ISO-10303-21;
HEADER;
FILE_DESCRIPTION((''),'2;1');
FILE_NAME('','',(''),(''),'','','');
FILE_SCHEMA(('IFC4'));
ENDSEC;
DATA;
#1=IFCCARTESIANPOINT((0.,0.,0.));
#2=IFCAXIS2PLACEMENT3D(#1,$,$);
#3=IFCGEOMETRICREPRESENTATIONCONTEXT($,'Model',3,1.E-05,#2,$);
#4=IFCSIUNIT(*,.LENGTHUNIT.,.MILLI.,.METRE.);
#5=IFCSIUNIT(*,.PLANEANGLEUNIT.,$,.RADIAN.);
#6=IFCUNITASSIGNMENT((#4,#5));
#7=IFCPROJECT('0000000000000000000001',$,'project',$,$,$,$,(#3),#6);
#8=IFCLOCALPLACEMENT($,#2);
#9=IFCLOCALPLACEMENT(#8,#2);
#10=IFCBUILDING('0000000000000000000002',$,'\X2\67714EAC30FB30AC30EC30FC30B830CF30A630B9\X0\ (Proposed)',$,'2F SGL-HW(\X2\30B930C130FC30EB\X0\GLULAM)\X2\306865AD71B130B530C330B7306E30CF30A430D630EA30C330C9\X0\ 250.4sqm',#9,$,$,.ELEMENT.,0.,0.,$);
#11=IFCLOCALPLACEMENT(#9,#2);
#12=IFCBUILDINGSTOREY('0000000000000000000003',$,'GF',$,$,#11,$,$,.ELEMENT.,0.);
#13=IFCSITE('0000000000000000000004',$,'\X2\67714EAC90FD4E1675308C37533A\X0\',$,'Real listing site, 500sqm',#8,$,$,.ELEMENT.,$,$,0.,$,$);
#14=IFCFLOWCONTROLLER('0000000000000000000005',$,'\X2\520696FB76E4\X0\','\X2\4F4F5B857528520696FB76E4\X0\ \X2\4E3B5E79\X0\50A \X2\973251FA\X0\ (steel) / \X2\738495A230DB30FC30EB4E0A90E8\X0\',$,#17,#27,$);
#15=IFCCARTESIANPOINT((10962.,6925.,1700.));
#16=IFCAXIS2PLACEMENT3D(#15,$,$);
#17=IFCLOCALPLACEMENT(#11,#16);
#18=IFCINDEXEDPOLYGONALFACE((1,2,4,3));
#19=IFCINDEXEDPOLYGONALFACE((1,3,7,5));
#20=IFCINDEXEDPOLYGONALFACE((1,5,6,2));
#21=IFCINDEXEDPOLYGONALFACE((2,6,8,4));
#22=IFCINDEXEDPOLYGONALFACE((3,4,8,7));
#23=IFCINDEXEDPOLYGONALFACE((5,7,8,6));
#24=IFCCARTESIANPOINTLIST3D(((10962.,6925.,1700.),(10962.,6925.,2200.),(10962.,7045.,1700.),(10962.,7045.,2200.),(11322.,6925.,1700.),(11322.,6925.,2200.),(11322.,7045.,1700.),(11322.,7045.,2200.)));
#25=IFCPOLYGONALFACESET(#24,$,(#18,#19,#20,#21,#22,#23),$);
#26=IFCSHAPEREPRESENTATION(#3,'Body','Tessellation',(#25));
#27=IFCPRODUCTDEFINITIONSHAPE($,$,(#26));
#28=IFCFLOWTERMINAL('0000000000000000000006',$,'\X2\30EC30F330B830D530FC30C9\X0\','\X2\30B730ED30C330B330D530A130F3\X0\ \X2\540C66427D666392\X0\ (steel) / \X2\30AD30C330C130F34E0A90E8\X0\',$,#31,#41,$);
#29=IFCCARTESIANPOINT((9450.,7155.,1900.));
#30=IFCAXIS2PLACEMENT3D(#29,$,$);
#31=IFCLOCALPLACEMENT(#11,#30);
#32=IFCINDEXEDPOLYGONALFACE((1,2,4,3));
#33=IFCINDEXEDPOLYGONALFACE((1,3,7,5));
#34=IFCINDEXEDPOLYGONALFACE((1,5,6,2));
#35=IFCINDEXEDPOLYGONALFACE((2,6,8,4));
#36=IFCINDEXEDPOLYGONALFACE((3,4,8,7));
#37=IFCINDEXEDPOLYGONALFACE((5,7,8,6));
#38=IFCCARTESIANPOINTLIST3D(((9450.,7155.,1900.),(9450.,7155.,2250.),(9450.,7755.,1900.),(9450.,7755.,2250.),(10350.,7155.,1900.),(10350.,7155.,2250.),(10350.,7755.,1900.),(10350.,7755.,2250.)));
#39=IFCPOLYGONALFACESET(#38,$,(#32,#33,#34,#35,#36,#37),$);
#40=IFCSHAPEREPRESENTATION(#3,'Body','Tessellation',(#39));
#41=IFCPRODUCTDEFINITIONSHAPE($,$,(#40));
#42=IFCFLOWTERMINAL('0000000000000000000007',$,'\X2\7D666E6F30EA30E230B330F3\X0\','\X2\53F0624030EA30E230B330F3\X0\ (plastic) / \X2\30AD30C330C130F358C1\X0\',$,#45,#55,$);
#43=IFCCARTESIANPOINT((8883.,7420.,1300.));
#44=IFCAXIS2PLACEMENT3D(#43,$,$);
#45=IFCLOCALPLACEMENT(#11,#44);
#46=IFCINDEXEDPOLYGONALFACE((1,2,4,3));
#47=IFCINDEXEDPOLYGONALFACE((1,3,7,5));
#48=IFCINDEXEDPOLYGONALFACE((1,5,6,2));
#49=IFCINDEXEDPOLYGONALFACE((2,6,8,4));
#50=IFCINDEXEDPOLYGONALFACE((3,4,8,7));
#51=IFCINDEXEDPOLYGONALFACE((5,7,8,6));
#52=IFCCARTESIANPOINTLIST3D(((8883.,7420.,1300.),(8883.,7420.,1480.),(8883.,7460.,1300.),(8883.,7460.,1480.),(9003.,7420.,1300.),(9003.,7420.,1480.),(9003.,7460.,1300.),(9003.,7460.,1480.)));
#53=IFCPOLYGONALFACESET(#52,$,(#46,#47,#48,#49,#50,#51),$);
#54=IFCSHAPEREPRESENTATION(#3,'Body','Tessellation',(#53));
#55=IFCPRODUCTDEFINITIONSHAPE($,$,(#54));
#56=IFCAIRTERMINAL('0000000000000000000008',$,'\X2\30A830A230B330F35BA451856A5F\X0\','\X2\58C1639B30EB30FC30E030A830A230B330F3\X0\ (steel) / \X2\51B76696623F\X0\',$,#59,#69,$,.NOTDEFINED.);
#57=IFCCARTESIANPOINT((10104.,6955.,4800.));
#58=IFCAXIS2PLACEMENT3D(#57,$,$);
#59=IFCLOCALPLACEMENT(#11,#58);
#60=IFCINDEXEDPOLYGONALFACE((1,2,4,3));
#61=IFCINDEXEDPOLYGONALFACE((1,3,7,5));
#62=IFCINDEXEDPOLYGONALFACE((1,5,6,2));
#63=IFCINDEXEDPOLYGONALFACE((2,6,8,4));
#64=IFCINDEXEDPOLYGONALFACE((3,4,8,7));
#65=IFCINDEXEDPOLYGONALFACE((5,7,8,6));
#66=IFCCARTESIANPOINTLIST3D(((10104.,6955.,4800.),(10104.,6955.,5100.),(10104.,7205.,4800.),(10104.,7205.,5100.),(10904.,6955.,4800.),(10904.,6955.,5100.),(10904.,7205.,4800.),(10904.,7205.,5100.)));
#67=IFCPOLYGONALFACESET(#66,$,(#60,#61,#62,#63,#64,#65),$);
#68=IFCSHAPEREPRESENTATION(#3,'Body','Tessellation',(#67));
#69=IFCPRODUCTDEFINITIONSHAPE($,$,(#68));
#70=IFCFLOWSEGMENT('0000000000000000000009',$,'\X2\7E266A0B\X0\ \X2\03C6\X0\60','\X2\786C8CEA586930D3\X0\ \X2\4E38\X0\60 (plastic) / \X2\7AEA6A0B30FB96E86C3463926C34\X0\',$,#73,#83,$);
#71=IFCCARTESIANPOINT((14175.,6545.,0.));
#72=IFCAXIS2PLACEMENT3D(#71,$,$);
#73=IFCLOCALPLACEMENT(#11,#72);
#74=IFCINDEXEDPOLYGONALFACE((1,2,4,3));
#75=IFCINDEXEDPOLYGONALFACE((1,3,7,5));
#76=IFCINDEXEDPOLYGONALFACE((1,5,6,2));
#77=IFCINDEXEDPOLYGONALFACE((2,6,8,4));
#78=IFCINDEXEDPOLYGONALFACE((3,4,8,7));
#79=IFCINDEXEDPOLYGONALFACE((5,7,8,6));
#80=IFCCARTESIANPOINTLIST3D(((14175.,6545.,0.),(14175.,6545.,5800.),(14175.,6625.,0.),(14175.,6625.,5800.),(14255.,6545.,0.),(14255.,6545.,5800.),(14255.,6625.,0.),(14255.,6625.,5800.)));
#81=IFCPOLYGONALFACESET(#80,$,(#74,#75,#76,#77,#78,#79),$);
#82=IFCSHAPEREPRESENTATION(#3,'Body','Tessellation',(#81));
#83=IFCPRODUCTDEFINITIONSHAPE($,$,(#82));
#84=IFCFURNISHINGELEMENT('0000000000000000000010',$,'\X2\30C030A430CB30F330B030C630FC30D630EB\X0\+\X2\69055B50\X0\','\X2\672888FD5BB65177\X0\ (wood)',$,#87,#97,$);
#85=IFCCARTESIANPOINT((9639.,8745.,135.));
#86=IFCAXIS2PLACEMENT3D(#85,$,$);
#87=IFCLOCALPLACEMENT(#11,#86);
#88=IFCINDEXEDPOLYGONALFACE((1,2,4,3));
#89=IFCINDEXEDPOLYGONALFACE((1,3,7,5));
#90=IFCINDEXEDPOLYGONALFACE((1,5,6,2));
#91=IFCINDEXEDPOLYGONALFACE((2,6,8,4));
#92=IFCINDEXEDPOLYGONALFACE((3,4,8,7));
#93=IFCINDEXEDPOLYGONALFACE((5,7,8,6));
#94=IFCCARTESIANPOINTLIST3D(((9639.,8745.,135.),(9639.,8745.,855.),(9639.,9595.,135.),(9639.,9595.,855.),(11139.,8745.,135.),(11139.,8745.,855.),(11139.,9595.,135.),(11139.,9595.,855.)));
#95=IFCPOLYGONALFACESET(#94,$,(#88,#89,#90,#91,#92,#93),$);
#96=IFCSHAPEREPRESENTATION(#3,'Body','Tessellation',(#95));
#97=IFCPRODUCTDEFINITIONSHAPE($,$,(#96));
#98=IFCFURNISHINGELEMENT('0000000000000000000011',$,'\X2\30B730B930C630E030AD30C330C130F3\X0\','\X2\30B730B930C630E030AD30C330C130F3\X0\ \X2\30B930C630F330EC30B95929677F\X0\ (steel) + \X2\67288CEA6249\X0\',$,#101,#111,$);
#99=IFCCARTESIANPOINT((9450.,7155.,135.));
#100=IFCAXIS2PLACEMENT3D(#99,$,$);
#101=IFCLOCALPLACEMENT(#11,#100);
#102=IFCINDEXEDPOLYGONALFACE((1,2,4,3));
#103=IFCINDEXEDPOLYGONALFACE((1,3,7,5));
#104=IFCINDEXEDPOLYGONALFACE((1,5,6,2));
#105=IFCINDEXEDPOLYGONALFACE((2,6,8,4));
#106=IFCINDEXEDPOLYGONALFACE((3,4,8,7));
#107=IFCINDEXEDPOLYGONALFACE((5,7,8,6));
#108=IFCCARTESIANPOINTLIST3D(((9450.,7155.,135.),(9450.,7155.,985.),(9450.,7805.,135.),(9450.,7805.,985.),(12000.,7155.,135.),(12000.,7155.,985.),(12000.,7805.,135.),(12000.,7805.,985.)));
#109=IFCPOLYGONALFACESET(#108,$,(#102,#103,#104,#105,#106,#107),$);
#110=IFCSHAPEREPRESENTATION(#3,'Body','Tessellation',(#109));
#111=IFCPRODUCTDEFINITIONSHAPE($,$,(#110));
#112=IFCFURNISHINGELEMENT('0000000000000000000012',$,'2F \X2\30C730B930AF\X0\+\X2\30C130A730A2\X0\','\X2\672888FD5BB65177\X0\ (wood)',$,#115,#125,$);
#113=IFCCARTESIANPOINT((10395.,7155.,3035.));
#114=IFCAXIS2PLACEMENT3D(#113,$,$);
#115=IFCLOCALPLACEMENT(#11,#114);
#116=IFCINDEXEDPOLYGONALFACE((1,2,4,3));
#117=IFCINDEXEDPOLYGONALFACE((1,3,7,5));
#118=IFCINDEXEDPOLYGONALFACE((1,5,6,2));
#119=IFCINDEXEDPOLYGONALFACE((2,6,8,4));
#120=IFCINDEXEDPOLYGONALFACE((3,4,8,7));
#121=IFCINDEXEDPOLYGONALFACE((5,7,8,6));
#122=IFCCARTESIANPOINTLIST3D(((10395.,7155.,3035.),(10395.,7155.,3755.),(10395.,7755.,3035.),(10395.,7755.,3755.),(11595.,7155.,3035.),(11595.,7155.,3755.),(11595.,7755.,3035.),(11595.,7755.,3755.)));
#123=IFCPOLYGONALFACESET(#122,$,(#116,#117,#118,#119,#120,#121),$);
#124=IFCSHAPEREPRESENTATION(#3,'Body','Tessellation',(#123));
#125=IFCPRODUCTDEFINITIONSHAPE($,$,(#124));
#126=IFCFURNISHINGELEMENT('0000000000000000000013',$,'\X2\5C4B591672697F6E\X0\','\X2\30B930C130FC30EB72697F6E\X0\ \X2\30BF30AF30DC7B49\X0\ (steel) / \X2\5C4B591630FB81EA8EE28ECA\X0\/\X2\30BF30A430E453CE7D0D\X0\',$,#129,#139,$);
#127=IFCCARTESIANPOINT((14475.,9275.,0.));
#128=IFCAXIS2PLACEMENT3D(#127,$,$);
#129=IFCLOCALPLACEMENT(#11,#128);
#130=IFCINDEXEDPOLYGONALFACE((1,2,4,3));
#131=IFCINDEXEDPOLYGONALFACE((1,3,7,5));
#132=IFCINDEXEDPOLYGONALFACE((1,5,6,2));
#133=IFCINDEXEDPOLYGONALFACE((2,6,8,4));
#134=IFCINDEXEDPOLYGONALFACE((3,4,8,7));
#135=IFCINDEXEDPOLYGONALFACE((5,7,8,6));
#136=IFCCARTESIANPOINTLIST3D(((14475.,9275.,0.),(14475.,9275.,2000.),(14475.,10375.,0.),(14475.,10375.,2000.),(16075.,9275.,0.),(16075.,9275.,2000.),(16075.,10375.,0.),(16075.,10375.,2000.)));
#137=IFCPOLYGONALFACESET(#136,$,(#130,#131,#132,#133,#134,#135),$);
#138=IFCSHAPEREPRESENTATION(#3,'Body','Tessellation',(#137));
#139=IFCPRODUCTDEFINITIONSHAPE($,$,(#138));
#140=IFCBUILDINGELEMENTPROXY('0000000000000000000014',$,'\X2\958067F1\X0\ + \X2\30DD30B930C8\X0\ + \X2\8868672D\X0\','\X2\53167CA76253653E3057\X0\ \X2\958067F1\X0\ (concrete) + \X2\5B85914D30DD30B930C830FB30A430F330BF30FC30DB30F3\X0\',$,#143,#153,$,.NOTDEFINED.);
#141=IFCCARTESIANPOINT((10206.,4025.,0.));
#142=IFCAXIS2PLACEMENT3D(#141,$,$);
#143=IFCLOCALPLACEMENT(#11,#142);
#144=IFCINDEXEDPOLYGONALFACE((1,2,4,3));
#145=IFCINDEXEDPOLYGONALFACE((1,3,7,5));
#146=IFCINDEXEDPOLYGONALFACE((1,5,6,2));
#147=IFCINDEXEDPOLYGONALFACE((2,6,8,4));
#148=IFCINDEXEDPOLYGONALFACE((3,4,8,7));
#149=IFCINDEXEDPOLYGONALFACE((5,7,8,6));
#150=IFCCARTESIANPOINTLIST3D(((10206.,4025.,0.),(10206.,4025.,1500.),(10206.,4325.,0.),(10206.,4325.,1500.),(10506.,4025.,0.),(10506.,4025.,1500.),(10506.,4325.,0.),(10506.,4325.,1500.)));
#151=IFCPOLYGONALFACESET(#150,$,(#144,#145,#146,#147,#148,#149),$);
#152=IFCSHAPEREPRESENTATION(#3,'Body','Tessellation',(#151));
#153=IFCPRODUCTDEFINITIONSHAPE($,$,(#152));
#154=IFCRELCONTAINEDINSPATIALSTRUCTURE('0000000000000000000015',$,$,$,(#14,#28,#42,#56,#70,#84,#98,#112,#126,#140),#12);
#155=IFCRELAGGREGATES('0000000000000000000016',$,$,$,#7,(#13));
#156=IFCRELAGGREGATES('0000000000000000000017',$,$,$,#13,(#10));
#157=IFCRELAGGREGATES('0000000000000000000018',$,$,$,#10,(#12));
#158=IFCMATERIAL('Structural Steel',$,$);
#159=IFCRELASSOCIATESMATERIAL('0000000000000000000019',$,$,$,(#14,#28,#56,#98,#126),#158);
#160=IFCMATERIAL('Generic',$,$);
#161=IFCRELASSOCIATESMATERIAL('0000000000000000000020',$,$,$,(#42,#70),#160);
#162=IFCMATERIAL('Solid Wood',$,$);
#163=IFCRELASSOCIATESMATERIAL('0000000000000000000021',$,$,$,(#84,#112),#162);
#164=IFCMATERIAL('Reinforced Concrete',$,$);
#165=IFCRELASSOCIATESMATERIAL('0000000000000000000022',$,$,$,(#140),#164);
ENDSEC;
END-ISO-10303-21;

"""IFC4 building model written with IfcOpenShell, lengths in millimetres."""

from ifc_helpers import new_model, si_unit, frame, frame_2d, origin, place, context, project, spatial, rectangle, extrude, material, element, save


model = new_model("IFC4")

# Units and contexts
model_context = context("Model", 3, precision=1e-05, world=origin())
ifc_project = project(units=[si_unit("LENGTHUNIT", "METRE", prefix="MILLI"), si_unit("PLANEANGLEUNIT", "RADIAN")], contexts=[model_context])

# Site, building, storey
site_placement = place(None, origin())
site = spatial("IfcSite", under=ifc_project, at=site_placement, Name="東京都世田谷区", ObjectType="Real listing site, 500sqm", CompositionType="ELEMENT", RefElevation=0.0)
building_placement = place(site_placement, origin())
building = spatial("IfcBuilding", under=site, at=building_placement, Name="東京・ガレージハウス (Proposed)", ObjectType="2F SGL-HW(スチールGLULAM)と断熱サッシのハイブリッド 250.4sqm", CompositionType="ELEMENT", ElevationOfRefHeight=0.0, ElevationOfTerrain=0.0)
storey_placement = place(building_placement, origin())
storey = spatial("IfcBuildingStorey", under=building, at=storey_placement, Name="GF", CompositionType="ELEMENT", Elevation=0.0)

# Shared definitions
ifc_material_1 = material(Name="Solid Wood")
ifc_material_2 = material(Name="Structural Steel")

# Shared definitions
ifc_material_3 = material(Name="Reinforced Concrete")

# Flow controller
flow_controller_placement = place(storey_placement, frame((10962.0, 6925.0, 1700.0)))
element("IfcFlowController", 1, at=flow_controller_placement, inside=storey, material=ifc_material_2, Name="分電盤", Description="住宅用分電盤 主幹50A 露出 (steel) / 玄関ホール上部", context=model_context, shape_type="SweptSolid", body=[
    extrude(rectangle(XDim=360.0, YDim=120.0, at=frame_2d((180.0, 60.0))), frame((10962.0, 6925.0, 1700.0)), (0.0, 0.0, 1.0), 500.0),
])

# Flow terminals
flow_terminal_1_placement = place(storey_placement, frame((9450.0, 7155.0, 1900.0)))
element("IfcFlowTerminal", 2, at=flow_terminal_1_placement, inside=storey, material=ifc_material_2, Name="レンジフード", Description="シロッコファン 同時給排 (steel) / キッチン上部", context=model_context, shape_type="SweptSolid", body=[
    extrude(rectangle(XDim=900.0, YDim=600.0, at=frame_2d((450.0, 300.0))), frame((9450.0, 7155.0, 1900.0)), (0.0, 0.0, 1.0), 350.0),
])
ifc_material_4 = material(Name="Generic")
flow_terminal_2_placement = place(storey_placement, frame((8883.0, 7420.0, 1300.0)))
element("IfcFlowTerminal", 3, at=flow_terminal_2_placement, inside=storey, material=ifc_material_4, Name="給湯リモコン", Description="台所リモコン (plastic) / キッチン壁", context=model_context, shape_type="SweptSolid", body=[
    extrude(rectangle(XDim=120.0, YDim=40.0, at=frame_2d((60.0, 20.0))), frame((8883.0, 7420.0, 1300.0)), (0.0, 0.0, 1.0), 180.0),
])

# Air terminal
air_terminal_placement = place(storey_placement, frame((10104.0, 6955.0, 4800.0)))
element("IfcAirTerminal", 4, at=air_terminal_placement, inside=storey, material=ifc_material_2, Name="エアコン室内機", Description="壁掛ルームエアコン (steel) / 冷暖房", PredefinedType="NOTDEFINED", context=model_context, shape_type="SweptSolid", body=[
    extrude(rectangle(XDim=800.0, YDim=250.0, at=frame_2d((400.0, 125.0))), frame((10104.0, 6955.0, 4800.0)), (0.0, 0.0, 1.0), 300.0),
])

# Flow segment
flow_segment_placement = place(storey_placement, frame((14175.0, 6545.0, 0.0)))
element("IfcFlowSegment", 5, at=flow_segment_placement, inside=storey, material=ifc_material_4, Name="縦樋 φ60", Description="硬質塩ビ 丸60 (plastic) / 竪樋・雨水排水", context=model_context, shape_type="SweptSolid", body=[
    extrude(rectangle(XDim=80.0, YDim=80.0, at=frame_2d((40.0, 40.0))), frame((14175.0, 6545.0, 0.0)), (0.0, 0.0, 1.0), 5800.0),
])

# Furnishing elements
furnishing_1_placement = place(storey_placement, frame((9639.0, 8745.0, 135.0)))
element("IfcFurnishingElement", 6, at=furnishing_1_placement, inside=storey, material=ifc_material_1, Name="ダイニングテーブル+椅子", Description="木製家具 (wood)", context=model_context, shape_type="SweptSolid", body=[
    extrude(rectangle(XDim=1500.0, YDim=850.0, at=frame_2d((750.0, 425.0))), frame((9639.0, 8745.0, 135.0)), (0.0, 0.0, 1.0), 720.0),
])
furnishing_2_placement = place(storey_placement, frame((9450.0, 7155.0, 135.0)))
element("IfcFurnishingElement", 7, at=furnishing_2_placement, inside=storey, material=ifc_material_2, Name="システムキッチン", Description="システムキッチン ステンレス天板 (steel) + 木質扉", context=model_context, shape_type="SweptSolid", body=[
    extrude(rectangle(XDim=2550.0, YDim=650.0, at=frame_2d((1275.0, 325.0))), frame((9450.0, 7155.0, 135.0)), (0.0, 0.0, 1.0), 850.0),
])
furnishing_3_placement = place(storey_placement, frame((10395.0, 7155.0, 3035.0)))
element("IfcFurnishingElement", 8, at=furnishing_3_placement, inside=storey, material=ifc_material_1, Name="2F デスク+チェア", Description="木製家具 (wood)", context=model_context, shape_type="SweptSolid", body=[
    extrude(rectangle(XDim=1200.0, YDim=600.0, at=frame_2d((600.0, 300.0))), frame((10395.0, 7155.0, 3035.0)), (0.0, 0.0, 1.0), 720.0),
])
furnishing_4_placement = place(storey_placement, frame((14475.0, 9275.0, 0.0)))
element("IfcFurnishingElement", 9, at=furnishing_4_placement, inside=storey, material=ifc_material_2, Name="屋外物置", Description="スチール物置 タクボ等 (steel) / 屋外・自転車/タイヤ収納", context=model_context, shape_type="SweptSolid", body=[
    extrude(rectangle(XDim=1600.0, YDim=1100.0, at=frame_2d((800.0, 550.0))), frame((14475.0, 9275.0, 0.0)), (0.0, 0.0, 1.0), 2000.0),
])

# Building element proxy
proxy_placement = place(storey_placement, frame((10206.0, 4025.0, 0.0)))
element("IfcBuildingElementProxy", 10, at=proxy_placement, inside=storey, material=ifc_material_3, Name="門柱 + ポスト + 表札", Description="化粧打放し 門柱 (concrete) + 宅配ポスト・インターホン", PredefinedType="NOTDEFINED", context=model_context, shape_type="SweptSolid", body=[
    extrude(rectangle(XDim=300.0, YDim=300.0, at=frame_2d((150.0, 150.0))), frame((10206.0, 4025.0, 0.0)), (0.0, 0.0, 1.0), 1500.0),
])

save(model, "model.ifc")
